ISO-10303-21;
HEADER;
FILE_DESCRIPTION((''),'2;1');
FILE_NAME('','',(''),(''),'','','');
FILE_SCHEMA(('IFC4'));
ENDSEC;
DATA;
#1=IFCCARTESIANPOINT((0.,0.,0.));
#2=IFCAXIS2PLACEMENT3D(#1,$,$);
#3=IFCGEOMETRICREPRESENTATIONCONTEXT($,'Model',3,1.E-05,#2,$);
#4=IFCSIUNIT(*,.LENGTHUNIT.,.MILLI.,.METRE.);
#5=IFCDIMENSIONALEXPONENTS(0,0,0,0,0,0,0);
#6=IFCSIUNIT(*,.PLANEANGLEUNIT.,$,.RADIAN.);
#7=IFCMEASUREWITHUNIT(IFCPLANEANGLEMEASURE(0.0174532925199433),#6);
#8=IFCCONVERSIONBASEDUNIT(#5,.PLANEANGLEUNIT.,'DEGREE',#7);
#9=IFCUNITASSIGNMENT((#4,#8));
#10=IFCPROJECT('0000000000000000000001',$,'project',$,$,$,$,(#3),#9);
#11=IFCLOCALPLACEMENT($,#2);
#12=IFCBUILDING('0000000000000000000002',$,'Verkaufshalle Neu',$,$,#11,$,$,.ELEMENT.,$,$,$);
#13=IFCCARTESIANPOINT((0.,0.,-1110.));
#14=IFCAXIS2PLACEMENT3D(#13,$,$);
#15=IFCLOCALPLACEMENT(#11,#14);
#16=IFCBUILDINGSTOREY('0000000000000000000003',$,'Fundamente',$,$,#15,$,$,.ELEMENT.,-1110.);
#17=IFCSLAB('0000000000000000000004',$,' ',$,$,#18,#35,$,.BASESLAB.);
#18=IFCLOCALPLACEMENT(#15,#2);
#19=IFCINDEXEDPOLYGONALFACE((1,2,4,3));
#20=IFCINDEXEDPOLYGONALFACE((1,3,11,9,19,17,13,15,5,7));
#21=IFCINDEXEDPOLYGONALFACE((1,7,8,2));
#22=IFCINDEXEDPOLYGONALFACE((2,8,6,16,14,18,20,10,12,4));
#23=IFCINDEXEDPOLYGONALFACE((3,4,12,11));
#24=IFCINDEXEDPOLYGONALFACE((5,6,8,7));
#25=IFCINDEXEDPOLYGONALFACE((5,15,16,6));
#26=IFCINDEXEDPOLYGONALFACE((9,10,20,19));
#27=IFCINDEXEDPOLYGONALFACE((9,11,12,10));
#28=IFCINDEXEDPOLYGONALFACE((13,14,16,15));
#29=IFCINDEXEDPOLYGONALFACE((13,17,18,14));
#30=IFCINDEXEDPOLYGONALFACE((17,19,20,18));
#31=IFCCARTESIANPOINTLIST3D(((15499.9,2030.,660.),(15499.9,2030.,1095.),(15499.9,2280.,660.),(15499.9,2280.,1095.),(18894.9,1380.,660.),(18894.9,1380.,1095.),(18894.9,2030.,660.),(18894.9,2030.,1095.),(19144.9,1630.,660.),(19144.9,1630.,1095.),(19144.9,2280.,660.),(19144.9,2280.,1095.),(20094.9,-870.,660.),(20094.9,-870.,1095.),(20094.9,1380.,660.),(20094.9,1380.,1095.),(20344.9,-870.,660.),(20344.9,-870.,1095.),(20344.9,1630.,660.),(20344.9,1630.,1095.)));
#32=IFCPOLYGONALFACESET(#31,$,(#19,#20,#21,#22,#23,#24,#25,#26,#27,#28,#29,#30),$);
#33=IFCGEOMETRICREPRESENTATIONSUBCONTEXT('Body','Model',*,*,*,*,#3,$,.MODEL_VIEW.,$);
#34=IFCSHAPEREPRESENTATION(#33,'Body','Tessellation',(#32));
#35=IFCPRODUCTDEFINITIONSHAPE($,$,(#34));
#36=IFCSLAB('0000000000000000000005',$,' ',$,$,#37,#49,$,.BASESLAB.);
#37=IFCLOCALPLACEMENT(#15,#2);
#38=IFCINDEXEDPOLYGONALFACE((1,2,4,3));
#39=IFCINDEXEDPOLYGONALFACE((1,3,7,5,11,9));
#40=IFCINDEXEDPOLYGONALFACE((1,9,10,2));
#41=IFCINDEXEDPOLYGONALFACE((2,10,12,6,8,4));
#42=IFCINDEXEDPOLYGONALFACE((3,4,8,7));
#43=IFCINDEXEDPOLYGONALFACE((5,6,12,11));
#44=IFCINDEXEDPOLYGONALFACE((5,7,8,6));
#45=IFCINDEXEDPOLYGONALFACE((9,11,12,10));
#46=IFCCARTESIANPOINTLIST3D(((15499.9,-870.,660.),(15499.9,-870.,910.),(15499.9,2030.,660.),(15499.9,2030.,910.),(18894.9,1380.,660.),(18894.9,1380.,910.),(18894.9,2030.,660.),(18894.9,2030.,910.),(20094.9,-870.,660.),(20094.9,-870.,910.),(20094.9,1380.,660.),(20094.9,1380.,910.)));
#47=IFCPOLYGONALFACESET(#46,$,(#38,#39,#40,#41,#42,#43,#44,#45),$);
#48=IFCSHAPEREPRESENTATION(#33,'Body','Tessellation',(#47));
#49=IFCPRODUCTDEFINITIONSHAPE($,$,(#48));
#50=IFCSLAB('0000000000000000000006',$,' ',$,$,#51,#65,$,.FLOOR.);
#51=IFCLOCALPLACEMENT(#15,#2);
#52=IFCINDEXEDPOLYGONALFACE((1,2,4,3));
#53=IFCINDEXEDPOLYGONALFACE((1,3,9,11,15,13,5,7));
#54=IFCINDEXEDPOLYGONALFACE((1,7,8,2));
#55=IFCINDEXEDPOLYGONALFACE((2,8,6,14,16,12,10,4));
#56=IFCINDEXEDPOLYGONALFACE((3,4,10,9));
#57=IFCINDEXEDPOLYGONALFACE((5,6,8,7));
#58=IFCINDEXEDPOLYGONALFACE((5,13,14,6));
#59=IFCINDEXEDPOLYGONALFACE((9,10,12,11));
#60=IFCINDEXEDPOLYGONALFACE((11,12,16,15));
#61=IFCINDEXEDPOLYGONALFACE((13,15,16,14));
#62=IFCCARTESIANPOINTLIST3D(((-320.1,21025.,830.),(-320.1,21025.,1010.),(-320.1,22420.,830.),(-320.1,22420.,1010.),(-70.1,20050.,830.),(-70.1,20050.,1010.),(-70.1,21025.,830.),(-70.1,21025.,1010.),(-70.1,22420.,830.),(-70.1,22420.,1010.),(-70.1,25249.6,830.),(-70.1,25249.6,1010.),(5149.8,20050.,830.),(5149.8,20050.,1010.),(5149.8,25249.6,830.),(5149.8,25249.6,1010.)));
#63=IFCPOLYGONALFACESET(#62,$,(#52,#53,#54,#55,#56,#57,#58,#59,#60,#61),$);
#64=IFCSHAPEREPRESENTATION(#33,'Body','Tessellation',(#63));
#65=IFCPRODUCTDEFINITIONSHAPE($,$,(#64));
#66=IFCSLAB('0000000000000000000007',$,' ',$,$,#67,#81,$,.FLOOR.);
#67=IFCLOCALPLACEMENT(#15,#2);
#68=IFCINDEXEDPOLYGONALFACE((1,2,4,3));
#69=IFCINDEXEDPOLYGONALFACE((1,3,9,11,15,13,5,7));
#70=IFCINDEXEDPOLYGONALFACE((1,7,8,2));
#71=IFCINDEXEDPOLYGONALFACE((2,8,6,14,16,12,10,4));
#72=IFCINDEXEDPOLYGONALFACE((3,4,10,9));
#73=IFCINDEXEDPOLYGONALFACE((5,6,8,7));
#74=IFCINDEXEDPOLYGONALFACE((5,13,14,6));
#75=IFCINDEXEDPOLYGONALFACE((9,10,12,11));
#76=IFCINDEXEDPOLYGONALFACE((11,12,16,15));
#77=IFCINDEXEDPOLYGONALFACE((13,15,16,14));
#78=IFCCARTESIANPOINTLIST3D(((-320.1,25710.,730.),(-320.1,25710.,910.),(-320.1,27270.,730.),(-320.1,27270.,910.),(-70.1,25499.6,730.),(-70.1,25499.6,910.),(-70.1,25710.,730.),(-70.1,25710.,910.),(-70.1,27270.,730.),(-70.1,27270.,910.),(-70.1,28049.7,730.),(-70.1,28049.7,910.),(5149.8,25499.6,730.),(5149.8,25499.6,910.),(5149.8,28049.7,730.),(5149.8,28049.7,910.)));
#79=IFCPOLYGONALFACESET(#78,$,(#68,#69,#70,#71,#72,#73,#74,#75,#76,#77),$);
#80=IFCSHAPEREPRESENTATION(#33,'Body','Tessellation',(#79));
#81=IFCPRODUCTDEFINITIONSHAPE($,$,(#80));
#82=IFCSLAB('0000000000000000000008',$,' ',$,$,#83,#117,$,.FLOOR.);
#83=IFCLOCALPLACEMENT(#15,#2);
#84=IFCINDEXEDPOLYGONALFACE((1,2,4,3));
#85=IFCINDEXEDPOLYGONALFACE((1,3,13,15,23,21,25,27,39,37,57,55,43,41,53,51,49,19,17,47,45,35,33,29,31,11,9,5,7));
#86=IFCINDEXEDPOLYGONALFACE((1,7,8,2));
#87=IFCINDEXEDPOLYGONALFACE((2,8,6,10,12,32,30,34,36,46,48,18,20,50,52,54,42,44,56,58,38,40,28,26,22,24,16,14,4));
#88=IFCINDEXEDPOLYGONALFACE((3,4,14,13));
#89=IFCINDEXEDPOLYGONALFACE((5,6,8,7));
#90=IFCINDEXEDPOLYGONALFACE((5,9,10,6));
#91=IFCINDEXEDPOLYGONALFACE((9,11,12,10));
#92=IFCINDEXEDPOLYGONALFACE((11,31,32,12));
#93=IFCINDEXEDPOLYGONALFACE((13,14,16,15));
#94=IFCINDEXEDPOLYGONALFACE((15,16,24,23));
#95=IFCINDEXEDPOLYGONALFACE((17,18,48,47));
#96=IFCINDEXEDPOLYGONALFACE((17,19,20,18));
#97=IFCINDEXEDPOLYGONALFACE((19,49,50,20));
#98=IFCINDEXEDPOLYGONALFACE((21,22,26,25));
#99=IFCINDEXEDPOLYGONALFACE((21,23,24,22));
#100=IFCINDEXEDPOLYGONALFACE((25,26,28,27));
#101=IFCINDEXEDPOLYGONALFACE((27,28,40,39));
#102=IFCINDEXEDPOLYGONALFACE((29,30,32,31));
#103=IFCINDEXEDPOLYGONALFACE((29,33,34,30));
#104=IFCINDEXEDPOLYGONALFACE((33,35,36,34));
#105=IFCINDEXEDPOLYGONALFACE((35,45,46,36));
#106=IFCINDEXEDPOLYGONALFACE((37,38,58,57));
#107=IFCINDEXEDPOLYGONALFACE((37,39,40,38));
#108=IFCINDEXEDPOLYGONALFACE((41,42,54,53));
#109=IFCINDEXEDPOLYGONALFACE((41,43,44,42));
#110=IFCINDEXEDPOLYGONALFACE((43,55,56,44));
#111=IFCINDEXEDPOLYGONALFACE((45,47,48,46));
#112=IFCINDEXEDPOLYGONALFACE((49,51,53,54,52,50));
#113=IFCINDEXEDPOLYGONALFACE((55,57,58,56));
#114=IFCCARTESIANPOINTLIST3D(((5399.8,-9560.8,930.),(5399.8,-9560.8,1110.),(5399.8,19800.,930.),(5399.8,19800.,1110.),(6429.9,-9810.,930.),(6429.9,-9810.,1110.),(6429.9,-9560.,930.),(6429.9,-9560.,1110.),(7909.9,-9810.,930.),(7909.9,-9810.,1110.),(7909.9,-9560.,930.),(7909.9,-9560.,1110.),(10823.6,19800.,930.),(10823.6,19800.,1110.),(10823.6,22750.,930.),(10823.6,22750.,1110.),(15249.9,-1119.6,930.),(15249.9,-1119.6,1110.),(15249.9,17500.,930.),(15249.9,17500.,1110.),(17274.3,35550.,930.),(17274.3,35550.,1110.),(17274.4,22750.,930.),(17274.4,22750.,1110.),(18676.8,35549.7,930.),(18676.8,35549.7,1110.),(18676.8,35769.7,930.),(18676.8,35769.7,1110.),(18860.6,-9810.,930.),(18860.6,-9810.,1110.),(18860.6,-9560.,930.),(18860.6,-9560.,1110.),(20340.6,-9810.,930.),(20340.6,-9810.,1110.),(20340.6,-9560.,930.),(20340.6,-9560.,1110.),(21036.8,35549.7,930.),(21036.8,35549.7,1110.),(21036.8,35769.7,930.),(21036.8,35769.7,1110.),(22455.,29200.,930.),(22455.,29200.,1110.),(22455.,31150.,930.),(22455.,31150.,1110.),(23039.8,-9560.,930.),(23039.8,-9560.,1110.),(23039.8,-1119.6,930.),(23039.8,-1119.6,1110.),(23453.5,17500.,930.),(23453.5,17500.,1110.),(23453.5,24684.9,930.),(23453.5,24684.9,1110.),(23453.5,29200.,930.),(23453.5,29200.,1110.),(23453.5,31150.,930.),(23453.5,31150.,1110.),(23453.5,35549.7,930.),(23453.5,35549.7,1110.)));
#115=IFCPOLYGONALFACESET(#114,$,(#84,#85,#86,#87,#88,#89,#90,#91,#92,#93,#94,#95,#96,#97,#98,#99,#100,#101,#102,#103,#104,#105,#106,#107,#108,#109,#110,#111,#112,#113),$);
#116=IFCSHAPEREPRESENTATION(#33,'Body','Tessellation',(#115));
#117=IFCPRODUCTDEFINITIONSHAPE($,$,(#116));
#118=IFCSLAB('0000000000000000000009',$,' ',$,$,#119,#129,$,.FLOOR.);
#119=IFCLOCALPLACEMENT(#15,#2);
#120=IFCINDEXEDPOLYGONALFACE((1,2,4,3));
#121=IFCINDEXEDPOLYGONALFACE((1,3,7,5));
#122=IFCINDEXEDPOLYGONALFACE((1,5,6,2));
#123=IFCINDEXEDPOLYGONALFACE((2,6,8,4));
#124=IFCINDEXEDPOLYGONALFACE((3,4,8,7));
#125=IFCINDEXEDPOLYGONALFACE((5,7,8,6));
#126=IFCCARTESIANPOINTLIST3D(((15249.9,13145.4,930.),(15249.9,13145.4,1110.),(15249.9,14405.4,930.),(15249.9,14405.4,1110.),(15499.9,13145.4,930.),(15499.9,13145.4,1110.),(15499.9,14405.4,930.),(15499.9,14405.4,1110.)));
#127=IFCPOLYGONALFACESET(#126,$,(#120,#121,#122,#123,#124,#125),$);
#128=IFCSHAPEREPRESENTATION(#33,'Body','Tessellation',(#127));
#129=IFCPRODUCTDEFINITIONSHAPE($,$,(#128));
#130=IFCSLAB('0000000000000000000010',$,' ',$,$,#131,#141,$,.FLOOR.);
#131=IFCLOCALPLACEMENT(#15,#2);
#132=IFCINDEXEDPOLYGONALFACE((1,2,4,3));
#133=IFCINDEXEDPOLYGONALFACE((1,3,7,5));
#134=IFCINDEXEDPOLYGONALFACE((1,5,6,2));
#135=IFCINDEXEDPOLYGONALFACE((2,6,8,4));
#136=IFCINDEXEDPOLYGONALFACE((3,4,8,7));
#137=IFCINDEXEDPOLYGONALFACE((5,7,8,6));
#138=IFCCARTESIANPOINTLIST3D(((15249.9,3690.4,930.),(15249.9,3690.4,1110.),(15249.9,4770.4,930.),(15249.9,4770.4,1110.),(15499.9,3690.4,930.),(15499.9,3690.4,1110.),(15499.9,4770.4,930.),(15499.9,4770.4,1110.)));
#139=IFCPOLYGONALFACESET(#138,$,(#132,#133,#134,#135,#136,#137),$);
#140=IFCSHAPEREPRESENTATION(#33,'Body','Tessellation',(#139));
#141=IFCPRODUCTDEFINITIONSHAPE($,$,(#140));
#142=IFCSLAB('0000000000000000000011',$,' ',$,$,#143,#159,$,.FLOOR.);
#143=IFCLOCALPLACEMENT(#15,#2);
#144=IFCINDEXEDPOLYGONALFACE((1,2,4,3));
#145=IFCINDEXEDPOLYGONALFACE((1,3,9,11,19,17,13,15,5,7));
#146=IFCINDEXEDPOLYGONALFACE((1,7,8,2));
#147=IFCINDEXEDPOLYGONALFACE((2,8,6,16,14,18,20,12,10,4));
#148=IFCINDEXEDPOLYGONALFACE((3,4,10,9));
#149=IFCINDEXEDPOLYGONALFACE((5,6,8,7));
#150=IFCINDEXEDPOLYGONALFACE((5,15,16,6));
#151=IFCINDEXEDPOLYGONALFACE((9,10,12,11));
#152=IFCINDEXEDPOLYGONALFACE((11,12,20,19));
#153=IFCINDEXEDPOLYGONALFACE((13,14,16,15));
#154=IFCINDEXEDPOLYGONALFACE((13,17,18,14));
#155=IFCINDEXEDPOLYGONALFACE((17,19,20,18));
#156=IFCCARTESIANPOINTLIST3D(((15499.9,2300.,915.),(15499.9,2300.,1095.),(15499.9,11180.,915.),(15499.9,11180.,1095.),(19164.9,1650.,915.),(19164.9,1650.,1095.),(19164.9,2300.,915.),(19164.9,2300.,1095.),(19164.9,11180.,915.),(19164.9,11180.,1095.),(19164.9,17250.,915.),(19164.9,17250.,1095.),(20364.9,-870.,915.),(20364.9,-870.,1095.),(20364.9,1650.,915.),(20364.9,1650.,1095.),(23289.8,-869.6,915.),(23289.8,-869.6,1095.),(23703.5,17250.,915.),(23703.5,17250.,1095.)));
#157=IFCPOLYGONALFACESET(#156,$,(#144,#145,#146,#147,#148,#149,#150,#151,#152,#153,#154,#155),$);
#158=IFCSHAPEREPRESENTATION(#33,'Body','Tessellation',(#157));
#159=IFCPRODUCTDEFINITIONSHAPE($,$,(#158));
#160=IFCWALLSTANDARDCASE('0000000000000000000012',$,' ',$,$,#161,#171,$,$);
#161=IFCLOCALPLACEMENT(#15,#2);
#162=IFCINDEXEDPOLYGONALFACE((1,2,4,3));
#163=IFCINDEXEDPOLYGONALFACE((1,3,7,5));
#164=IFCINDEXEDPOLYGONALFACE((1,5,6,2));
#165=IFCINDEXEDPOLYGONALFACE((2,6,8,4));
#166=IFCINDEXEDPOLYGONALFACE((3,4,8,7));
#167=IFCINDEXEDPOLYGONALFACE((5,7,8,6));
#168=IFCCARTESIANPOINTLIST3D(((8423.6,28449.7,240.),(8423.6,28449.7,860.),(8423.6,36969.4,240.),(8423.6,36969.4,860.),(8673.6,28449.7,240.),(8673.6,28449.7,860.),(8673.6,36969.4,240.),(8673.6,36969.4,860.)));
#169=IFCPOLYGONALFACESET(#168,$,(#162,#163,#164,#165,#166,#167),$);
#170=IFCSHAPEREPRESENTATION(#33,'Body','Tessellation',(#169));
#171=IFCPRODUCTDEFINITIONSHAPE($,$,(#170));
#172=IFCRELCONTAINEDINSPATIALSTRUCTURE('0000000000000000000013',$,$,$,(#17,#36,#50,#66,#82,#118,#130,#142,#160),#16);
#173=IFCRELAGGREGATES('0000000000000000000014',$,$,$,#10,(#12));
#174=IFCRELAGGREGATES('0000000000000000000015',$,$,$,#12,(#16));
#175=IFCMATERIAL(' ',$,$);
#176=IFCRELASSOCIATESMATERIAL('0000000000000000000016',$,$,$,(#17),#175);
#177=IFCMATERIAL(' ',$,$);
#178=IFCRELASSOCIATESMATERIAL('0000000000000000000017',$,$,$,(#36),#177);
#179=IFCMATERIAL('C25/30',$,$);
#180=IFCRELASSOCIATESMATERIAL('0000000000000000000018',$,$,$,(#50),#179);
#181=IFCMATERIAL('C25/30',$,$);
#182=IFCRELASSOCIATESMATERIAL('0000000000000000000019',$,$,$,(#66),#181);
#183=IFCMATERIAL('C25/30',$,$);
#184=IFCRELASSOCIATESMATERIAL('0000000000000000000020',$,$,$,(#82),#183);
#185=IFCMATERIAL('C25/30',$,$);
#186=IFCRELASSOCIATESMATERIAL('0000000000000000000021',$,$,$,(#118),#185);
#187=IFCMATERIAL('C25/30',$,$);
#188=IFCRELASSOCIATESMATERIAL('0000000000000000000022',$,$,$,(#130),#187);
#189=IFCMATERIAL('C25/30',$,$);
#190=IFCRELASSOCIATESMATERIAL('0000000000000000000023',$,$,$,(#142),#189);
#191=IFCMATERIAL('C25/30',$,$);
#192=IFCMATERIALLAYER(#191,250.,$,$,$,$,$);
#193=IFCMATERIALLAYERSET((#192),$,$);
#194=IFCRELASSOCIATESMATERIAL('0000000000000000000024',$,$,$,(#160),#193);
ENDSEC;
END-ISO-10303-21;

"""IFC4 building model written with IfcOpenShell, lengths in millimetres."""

from ifc_helpers import new_model, entity, si_unit, converted_unit, frame, frame_2d, origin, origin_with_axes, place, context, subcontext, project, spatial, polyline, rectangle, outline, extrude, material, layer, layer_set, layer_usage, element, save


model = new_model("IFC4")

# Units and contexts
model_context = context("Model", 3, precision=1e-05, world=origin())
body_context = subcontext(model_context, "Body", "Model", "MODEL_VIEW")
ifc_project = project(units=[si_unit("LENGTHUNIT", "METRE", prefix="MILLI"), converted_unit("PLANEANGLEUNIT", "DEGREE", entity("IfcPlaneAngleMeasure", 0.0174532925199433), si_unit("PLANEANGLEUNIT", "RADIAN"), dimensions=[0, 0, 0, 0, 0, 0, 0])], contexts=[model_context])

# Building, storey
building_placement = place(None, origin())
building = spatial("IfcBuilding", under=ifc_project, at=building_placement, Name="Verkaufshalle Neu", CompositionType="ELEMENT")
storey_placement = place(building_placement, frame((0.0, 0.0, -1110.0)))
storey = spatial("IfcBuildingStorey", under=building, at=storey_placement, Name="Fundamente", CompositionType="ELEMENT", Elevation=-1110.0)

# Slabs
ifc_material_1 = material(Name=" ")
slab_1_placement = place(storey_placement, frame((15499.9, -870.0, 660.0)))
element("IfcSlab", 1, at=slab_1_placement, inside=storey, material=ifc_material_1, Name=" ", PredefinedType="BASESLAB", context=body_context, shape_type="SweptSolid", body=[
    extrude(outline(polyline([(0.0, 2900.0), (3395.0, 2900.0), (3395.0, 2250.0), (4595.0, 2250.0), (4595.0, 0.0), (4845.0, 0.0), (4845.0, 2500.0), (3645.0, 2500.0), (3645.0, 3150.0), (0.0, 3150.0), (0.0, 2900.0)])), origin_with_axes(), (0.0, 0.0, 1.0), 435.0),
])
ifc_material_2 = material(Name=" ")
slab_2_placement = place(storey_placement, frame((15499.9, -870.0, 660.0)))
element("IfcSlab", 2, at=slab_2_placement, inside=storey, material=ifc_material_2, Name=" ", PredefinedType="BASESLAB", context=body_context, shape_type="SweptSolid", body=[
    extrude(outline(polyline([(0.0, 2900.0), (0.0, 0.0), (4595.0, 0.0), (4595.0, 2250.0), (3395.0, 2250.0), (3395.0, 2900.0), (0.0, 2900.0)])), origin_with_axes(), (0.0, 0.0, 1.0), 250.0),
])
ifc_material_3 = material(Name="C25/30")
slab_3_placement = place(storey_placement, frame((-320.1, 20050.0, 830.0)))
element("IfcSlab", 3, at=slab_3_placement, inside=storey, material=ifc_material_3, Name=" ", PredefinedType="FLOOR", context=body_context, shape_type="SweptSolid", body=[
    extrude(outline(polyline([(250.0, 5199.6), (250.0, 2370.0), (0.0, 2370.0), (0.0, 975.0), (250.0, 975.0), (250.0, 0.0), (5469.8, 0.0), (5469.8, 5199.6), (250.0, 5199.6)])), origin_with_axes(), (0.0, 0.0, 1.0), 180.0),
])
ifc_material_4 = material(Name="C25/30")
slab_4_placement = place(storey_placement, frame((-320.1, 25499.6, 730.0)))
element("IfcSlab", 4, at=slab_4_placement, inside=storey, material=ifc_material_4, Name=" ", PredefinedType="FLOOR", context=body_context, shape_type="SweptSolid", body=[
    extrude(outline(polyline([(0.0, 1770.4), (0.0, 210.4), (250.0, 210.4), (250.0, 0.0), (5469.8, 0.0), (5469.8, 2550.1), (250.0, 2550.1), (250.0, 1770.4), (0.0, 1770.4)])), origin_with_axes(), (0.0, 0.0, 1.0), 180.0),
])
ifc_material_5 = material(Name="C25/30")
slab_5_placement = place(storey_placement, frame((5399.8, -9810.0, 930.0)))
element("IfcSlab", 5, at=slab_5_placement, inside=storey, material=ifc_material_5, Name=" ", PredefinedType="FLOOR", context=body_context, shape_type="SweptSolid", body=[
    extrude(outline(polyline([(2510.2, 250.0), (13460.9, 250.0), (13460.9, 0.0), (14940.9, 0.0), (14940.9, 250.0), (17640.0, 250.0), (17640.0, 8690.4), (9850.2, 8690.4), (9850.2, 27310.0), (18053.8, 27310.0), (18053.8, 34494.9), (18053.8, 39010.0), (17055.2, 39010.0), (17055.2, 40960.0), (18053.8, 40960.0), (18053.8, 45359.7), (15637.0, 45359.7), (15637.0, 45579.7), (13277.0, 45579.7), (13277.0, 45359.7), (11874.6, 45360.0), (11874.6, 32560.0), (11874.6, 32560.0), (5423.9, 32560.0), (5423.9, 29610.0), (0.0, 29610.0), (0.0, 249.2), (1030.2, 250.0), (1030.2, 0.0), (2510.2, 0.0), (2510.2, 250.0)])), origin_with_axes(), (0.0, 0.0, 1.0), 180.0),
])
ifc_material_6 = material(Name="C25/30")
slab_6_placement = place(storey_placement, frame((15249.9, 13145.4, 930.0)))
element("IfcSlab", 6, at=slab_6_placement, inside=storey, material=ifc_material_6, Name=" ", PredefinedType="FLOOR", context=body_context, shape_type="SweptSolid", body=[
    extrude(rectangle(XDim=1260.0, YDim=250.0, at=frame_2d((125.0, -630.0), x_axis=(0.0, -1.0))), frame((0.0, 1260.0, 0.0), z_axis=(0.0, 0.0, 1.0), x_axis=(1.0, 0.0, 0.0)), (0.0, 0.0, 1.0), 180.0),
])
ifc_material_7 = material(Name="C25/30")
slab_7_placement = place(storey_placement, frame((15249.9, 3690.4, 930.0)))
element("IfcSlab", 7, at=slab_7_placement, inside=storey, material=ifc_material_7, Name=" ", PredefinedType="FLOOR", context=body_context, shape_type="SweptSolid", body=[
    extrude(rectangle(XDim=1080.0, YDim=250.0, at=frame_2d((125.0, -540.0), x_axis=(0.0, -1.0))), frame((0.0, 1080.0, 0.0), z_axis=(0.0, 0.0, 1.0), x_axis=(1.0, 0.0, 0.0)), (0.0, 0.0, 1.0), 180.0),
])
ifc_material_8 = material(Name="C25/30")
slab_8_placement = place(storey_placement, frame((15499.9, -870.0, 915.0)))
element("IfcSlab", 8, at=slab_8_placement, inside=storey, material=ifc_material_8, Name=" ", PredefinedType="FLOOR", context=body_context, shape_type="SweptSolid", body=[
    extrude(outline(polyline([(0.0, 3170.0), (3665.0, 3170.0), (3665.0, 2520.0), (4865.0, 2520.0), (4865.0, 0.0), (7789.8, 0.4), (8203.6, 18120.0), (3665.0, 18120.0), (3665.0, 12050.0), (0.0, 12050.0), (0.0, 3170.0)])), origin_with_axes(), (0.0, 0.0, 1.0), 180.0),
])

# Wall
ifc_material_9 = material(Name="C25/30")
ifc_layer = layer(ifc_material_9, 250.0)
ifc_layer_set = layer_set([ifc_layer])
ifc_layer_usage = layer_usage(ifc_layer_set, "AXIS2", "POSITIVE", 0.0)
wall_placement = place(storey_placement, frame((8673.6, 28449.7, 240.0), z_axis=(0.0, 0.0, 1.0), x_axis=(0.0, 1.0, 0.0)))
element("IfcWallStandardCase", 9, at=wall_placement, inside=storey, material=ifc_layer_usage, Name=" ", context=body_context, shape_type="SweptSolid", body=[
    extrude(outline(polyline([(0.0, -250.0), (8519.7, -250.0), (8519.7, 0.0), (0.0, 0.0), (0.0, -250.0)])), frame((0.0, 250.0, 0.0), z_axis=(0.0, 0.0, 1.0), x_axis=(1.0, 0.0, 0.0)), (0.0, 0.0, 1.0), 620.0),
])

save(model, "model.ifc")
